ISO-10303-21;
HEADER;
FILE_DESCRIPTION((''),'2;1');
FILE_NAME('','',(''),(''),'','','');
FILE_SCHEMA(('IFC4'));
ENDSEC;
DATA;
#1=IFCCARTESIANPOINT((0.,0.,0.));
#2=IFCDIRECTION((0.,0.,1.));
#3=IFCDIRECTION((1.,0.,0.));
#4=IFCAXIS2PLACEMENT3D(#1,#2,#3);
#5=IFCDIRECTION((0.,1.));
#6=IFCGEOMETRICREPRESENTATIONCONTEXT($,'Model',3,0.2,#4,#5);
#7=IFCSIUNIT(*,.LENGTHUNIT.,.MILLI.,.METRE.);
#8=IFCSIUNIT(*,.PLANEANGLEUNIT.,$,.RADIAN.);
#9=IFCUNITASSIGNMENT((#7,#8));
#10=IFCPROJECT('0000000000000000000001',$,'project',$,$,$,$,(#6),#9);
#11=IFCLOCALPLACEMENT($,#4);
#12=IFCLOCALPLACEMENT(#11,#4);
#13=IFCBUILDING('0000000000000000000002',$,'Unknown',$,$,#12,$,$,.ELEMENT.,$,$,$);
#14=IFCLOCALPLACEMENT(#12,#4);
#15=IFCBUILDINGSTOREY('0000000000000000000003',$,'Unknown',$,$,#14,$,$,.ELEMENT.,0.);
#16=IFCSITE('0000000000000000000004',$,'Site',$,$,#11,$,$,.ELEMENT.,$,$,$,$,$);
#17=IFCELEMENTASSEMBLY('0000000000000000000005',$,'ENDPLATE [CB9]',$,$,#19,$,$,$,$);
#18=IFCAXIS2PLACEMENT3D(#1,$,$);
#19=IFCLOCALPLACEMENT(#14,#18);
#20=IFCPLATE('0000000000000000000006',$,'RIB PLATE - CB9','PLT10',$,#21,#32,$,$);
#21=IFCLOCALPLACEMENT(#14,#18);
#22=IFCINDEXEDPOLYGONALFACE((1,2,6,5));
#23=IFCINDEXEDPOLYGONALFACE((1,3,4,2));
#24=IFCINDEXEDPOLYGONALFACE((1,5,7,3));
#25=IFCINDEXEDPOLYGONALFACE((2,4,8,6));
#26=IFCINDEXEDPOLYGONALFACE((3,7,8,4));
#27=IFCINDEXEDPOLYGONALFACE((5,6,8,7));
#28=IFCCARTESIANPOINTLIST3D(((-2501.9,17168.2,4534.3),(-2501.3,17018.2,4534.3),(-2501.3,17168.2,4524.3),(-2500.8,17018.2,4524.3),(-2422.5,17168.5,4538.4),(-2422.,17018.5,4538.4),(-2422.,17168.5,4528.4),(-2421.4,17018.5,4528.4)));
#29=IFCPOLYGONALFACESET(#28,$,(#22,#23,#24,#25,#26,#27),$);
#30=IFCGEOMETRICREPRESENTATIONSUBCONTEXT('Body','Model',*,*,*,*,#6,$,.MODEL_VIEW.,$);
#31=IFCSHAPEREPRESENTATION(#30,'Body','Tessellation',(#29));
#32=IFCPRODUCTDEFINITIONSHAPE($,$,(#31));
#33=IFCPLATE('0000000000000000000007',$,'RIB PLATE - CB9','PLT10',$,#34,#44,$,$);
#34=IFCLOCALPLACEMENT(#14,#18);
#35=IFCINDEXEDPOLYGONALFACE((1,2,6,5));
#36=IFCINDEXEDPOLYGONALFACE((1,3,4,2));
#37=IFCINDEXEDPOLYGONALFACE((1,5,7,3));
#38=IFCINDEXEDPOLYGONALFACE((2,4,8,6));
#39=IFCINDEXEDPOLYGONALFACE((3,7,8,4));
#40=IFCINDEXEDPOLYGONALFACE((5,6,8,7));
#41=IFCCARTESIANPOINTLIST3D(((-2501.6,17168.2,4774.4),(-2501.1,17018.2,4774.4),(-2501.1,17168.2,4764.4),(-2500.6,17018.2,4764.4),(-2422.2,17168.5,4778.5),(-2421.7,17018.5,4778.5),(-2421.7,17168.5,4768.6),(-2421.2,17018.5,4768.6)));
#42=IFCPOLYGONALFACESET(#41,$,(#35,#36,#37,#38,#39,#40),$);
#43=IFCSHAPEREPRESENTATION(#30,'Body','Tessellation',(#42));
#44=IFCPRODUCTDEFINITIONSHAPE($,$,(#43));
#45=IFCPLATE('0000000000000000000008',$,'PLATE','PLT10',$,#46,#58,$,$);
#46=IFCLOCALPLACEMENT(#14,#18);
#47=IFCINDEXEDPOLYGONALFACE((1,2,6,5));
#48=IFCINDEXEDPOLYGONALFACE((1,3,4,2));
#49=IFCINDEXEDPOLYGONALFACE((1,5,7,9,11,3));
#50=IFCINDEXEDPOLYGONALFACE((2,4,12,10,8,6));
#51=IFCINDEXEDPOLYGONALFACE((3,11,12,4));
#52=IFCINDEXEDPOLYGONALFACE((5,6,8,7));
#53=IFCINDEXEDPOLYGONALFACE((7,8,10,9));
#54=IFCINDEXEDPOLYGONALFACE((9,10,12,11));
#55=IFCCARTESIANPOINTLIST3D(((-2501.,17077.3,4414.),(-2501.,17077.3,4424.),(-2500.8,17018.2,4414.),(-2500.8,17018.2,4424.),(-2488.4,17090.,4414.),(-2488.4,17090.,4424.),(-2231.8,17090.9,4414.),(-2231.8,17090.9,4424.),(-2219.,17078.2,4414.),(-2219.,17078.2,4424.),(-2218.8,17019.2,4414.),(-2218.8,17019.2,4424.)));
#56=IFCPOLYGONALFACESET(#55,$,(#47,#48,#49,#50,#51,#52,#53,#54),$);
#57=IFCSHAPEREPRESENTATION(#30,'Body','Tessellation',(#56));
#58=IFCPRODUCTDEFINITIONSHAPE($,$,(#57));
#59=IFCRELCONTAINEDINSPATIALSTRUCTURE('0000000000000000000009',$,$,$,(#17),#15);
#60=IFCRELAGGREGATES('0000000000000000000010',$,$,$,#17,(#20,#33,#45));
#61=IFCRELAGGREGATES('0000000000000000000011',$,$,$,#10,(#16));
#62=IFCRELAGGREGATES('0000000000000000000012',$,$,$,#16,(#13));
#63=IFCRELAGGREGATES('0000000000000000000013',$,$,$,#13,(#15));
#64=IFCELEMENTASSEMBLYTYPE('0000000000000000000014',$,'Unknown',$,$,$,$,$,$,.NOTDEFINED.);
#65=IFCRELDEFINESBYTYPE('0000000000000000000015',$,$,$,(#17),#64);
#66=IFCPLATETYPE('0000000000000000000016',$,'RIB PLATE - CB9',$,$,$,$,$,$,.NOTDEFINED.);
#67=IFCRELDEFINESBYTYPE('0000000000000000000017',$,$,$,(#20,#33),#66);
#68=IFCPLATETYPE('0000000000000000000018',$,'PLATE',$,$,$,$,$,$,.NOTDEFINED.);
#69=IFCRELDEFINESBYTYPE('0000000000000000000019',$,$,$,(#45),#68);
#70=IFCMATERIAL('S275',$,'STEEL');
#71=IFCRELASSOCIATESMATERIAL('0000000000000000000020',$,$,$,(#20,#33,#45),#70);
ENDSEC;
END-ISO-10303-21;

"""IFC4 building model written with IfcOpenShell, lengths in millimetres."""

from ifc_helpers import new_model, si_unit, direction, frame, origin_with_axes, place, context, subcontext, project, spatial, line, indexed_curve, outline, extrude, material, material_profile, profile_set, profile_usage, type_object, element, aggregate, save


model = new_model("IFC4")

# Units and contexts
model_context = context("Model", 3, precision=0.2, world=origin_with_axes(), true_north=direction((0.0, 1.0)))
body_context = subcontext(model_context, "Body", "Model", "MODEL_VIEW")
ifc_project = project(units=[si_unit("LENGTHUNIT", "METRE", prefix="MILLI"), si_unit("PLANEANGLEUNIT", "RADIAN")], contexts=[model_context])

# Site, building, storey
site_placement = place(None, origin_with_axes())
site = spatial("IfcSite", under=ifc_project, at=site_placement, Name="Site", CompositionType="ELEMENT")
building_placement = place(site_placement, origin_with_axes())
building = spatial("IfcBuilding", under=site, at=building_placement, Name="Unknown", CompositionType="ELEMENT")
storey_placement = place(building_placement, origin_with_axes())
storey = spatial("IfcBuildingStorey", under=building, at=storey_placement, Name="Unknown", CompositionType="ELEMENT", Elevation=0.0)

# Element assembly
element_assembly_type = type_object("IfcElementAssemblyType", Name="Unknown", PredefinedType="NOTDEFINED")
ifc_material_1 = material(Name="S275", Category="STEEL")
assembly_1_placement = place(storey_placement, frame((-2422.5, 17083.2, 4892.0), z_axis=(0.003456, -0.999994, 0.0), x_axis=(0.0, 0.0, -1.0)))
assembly_1 = element("IfcElementAssembly", 1, at=assembly_1_placement, inside=storey, type_object=element_assembly_type, Name="ENDPLATE [CB9]")

# Plates
ifc_material_profile_1 = material_profile(ifc_material_1, outline(indexed_curve([(0.0, 0.0), (150.0, 0.0), (150.0, 79.5), (0.0, 79.5)], segments=[line(1, 2, 3, 4, 1)])), Name="PLT10")
ifc_profile_set_1 = profile_set([ifc_material_profile_1])
ifc_profile_usage_1 = profile_usage(ifc_profile_set_1, cardinal=5)
plate_type_1 = type_object("IfcPlateType", Name="RIB PLATE - CB9", PredefinedType="NOTDEFINED")
plate_1_placement = place(assembly_1_placement, frame((358.6, 0.6, -85.2), z_axis=(0.99863, 0.052336, 0.0), x_axis=(0.0, 0.0, 1.0)))
plate_1 = element("IfcPlate", 2, at=plate_1_placement, type_object=plate_type_1, material=ifc_profile_usage_1, Name="RIB PLATE - CB9", Description="PLT10", context=body_context, shape_type="SolidModel", body=[
    extrude(outline(indexed_curve([(0.0, 0.0), (150.0, 0.0), (150.0, 79.5), (0.0, 79.5)], segments=[line(1, 2, 3, 4, 1)])), frame((0.0, 0.0, 5.0), z_axis=(0.0, 0.0, 1.0), x_axis=(1.0, 0.0, 0.0)), (0.0, 0.0, -1.0), 10.0),
])
plate_2_placement = place(assembly_1_placement, frame((118.4, 0.9, -85.2), z_axis=(0.99863, 0.052336, 0.0), x_axis=(0.0, 0.0, 1.0)))
plate_2 = element("IfcPlate", 3, at=plate_2_placement, type_object=plate_type_1, material=ifc_profile_usage_1, Name="RIB PLATE - CB9", Description="PLT10", context=body_context, shape_type="SolidModel", body=[
    extrude(outline(indexed_curve([(0.0, 0.0), (150.0, 0.0), (150.0, 79.5), (0.0, 79.5)], segments=[line(1, 2, 3, 4, 1)])), frame((0.0, 0.0, 5.0), z_axis=(0.0, 0.0, 1.0), x_axis=(1.0, 0.0, 0.0)), (0.0, 0.0, -1.0), 10.0),
])
ifc_material_profile_2 = material_profile(ifc_material_1, outline(indexed_curve([(0.0, 12.7), (12.7, 0.0), (71.8, 0.0), (71.8, 282.0), (12.7, 282.0), (0.0, 269.3)], segments=[line(1, 2, 3, 4, 5, 6, 1)])), Name="PLT10")
ifc_profile_set_2 = profile_set([ifc_material_profile_2])
ifc_profile_usage_2 = profile_usage(ifc_profile_set_2, cardinal=2)
plate_type_2 = type_object("IfcPlateType", Name="PLATE", PredefinedType="NOTDEFINED")
plate_3_placement = place(assembly_1_placement, frame((473.0, 203.5, -7.0), z_axis=(1.0, 0.0, 0.0), x_axis=(0.0, 0.0, 1.0)))
plate_3 = element("IfcPlate", 4, at=plate_3_placement, type_object=plate_type_2, material=ifc_profile_usage_2, Name="PLATE", Description="PLT10", context=body_context, shape_type="SolidModel", body=[
    extrude(outline(indexed_curve([(0.0, 12.7), (12.7, 0.0), (71.8, 0.0), (71.8, 282.0), (12.7, 282.0), (0.0, 269.3)], segments=[line(1, 2, 3, 4, 5, 6, 1)])), frame((0.0, 0.0, 5.0), z_axis=(0.0, 0.0, 1.0), x_axis=(1.0, 0.0, 0.0)), (0.0, 0.0, -1.0), 10.0),
])

aggregate(assembly_1, [plate_1, plate_2, plate_3])

save(model, "model.ifc")
